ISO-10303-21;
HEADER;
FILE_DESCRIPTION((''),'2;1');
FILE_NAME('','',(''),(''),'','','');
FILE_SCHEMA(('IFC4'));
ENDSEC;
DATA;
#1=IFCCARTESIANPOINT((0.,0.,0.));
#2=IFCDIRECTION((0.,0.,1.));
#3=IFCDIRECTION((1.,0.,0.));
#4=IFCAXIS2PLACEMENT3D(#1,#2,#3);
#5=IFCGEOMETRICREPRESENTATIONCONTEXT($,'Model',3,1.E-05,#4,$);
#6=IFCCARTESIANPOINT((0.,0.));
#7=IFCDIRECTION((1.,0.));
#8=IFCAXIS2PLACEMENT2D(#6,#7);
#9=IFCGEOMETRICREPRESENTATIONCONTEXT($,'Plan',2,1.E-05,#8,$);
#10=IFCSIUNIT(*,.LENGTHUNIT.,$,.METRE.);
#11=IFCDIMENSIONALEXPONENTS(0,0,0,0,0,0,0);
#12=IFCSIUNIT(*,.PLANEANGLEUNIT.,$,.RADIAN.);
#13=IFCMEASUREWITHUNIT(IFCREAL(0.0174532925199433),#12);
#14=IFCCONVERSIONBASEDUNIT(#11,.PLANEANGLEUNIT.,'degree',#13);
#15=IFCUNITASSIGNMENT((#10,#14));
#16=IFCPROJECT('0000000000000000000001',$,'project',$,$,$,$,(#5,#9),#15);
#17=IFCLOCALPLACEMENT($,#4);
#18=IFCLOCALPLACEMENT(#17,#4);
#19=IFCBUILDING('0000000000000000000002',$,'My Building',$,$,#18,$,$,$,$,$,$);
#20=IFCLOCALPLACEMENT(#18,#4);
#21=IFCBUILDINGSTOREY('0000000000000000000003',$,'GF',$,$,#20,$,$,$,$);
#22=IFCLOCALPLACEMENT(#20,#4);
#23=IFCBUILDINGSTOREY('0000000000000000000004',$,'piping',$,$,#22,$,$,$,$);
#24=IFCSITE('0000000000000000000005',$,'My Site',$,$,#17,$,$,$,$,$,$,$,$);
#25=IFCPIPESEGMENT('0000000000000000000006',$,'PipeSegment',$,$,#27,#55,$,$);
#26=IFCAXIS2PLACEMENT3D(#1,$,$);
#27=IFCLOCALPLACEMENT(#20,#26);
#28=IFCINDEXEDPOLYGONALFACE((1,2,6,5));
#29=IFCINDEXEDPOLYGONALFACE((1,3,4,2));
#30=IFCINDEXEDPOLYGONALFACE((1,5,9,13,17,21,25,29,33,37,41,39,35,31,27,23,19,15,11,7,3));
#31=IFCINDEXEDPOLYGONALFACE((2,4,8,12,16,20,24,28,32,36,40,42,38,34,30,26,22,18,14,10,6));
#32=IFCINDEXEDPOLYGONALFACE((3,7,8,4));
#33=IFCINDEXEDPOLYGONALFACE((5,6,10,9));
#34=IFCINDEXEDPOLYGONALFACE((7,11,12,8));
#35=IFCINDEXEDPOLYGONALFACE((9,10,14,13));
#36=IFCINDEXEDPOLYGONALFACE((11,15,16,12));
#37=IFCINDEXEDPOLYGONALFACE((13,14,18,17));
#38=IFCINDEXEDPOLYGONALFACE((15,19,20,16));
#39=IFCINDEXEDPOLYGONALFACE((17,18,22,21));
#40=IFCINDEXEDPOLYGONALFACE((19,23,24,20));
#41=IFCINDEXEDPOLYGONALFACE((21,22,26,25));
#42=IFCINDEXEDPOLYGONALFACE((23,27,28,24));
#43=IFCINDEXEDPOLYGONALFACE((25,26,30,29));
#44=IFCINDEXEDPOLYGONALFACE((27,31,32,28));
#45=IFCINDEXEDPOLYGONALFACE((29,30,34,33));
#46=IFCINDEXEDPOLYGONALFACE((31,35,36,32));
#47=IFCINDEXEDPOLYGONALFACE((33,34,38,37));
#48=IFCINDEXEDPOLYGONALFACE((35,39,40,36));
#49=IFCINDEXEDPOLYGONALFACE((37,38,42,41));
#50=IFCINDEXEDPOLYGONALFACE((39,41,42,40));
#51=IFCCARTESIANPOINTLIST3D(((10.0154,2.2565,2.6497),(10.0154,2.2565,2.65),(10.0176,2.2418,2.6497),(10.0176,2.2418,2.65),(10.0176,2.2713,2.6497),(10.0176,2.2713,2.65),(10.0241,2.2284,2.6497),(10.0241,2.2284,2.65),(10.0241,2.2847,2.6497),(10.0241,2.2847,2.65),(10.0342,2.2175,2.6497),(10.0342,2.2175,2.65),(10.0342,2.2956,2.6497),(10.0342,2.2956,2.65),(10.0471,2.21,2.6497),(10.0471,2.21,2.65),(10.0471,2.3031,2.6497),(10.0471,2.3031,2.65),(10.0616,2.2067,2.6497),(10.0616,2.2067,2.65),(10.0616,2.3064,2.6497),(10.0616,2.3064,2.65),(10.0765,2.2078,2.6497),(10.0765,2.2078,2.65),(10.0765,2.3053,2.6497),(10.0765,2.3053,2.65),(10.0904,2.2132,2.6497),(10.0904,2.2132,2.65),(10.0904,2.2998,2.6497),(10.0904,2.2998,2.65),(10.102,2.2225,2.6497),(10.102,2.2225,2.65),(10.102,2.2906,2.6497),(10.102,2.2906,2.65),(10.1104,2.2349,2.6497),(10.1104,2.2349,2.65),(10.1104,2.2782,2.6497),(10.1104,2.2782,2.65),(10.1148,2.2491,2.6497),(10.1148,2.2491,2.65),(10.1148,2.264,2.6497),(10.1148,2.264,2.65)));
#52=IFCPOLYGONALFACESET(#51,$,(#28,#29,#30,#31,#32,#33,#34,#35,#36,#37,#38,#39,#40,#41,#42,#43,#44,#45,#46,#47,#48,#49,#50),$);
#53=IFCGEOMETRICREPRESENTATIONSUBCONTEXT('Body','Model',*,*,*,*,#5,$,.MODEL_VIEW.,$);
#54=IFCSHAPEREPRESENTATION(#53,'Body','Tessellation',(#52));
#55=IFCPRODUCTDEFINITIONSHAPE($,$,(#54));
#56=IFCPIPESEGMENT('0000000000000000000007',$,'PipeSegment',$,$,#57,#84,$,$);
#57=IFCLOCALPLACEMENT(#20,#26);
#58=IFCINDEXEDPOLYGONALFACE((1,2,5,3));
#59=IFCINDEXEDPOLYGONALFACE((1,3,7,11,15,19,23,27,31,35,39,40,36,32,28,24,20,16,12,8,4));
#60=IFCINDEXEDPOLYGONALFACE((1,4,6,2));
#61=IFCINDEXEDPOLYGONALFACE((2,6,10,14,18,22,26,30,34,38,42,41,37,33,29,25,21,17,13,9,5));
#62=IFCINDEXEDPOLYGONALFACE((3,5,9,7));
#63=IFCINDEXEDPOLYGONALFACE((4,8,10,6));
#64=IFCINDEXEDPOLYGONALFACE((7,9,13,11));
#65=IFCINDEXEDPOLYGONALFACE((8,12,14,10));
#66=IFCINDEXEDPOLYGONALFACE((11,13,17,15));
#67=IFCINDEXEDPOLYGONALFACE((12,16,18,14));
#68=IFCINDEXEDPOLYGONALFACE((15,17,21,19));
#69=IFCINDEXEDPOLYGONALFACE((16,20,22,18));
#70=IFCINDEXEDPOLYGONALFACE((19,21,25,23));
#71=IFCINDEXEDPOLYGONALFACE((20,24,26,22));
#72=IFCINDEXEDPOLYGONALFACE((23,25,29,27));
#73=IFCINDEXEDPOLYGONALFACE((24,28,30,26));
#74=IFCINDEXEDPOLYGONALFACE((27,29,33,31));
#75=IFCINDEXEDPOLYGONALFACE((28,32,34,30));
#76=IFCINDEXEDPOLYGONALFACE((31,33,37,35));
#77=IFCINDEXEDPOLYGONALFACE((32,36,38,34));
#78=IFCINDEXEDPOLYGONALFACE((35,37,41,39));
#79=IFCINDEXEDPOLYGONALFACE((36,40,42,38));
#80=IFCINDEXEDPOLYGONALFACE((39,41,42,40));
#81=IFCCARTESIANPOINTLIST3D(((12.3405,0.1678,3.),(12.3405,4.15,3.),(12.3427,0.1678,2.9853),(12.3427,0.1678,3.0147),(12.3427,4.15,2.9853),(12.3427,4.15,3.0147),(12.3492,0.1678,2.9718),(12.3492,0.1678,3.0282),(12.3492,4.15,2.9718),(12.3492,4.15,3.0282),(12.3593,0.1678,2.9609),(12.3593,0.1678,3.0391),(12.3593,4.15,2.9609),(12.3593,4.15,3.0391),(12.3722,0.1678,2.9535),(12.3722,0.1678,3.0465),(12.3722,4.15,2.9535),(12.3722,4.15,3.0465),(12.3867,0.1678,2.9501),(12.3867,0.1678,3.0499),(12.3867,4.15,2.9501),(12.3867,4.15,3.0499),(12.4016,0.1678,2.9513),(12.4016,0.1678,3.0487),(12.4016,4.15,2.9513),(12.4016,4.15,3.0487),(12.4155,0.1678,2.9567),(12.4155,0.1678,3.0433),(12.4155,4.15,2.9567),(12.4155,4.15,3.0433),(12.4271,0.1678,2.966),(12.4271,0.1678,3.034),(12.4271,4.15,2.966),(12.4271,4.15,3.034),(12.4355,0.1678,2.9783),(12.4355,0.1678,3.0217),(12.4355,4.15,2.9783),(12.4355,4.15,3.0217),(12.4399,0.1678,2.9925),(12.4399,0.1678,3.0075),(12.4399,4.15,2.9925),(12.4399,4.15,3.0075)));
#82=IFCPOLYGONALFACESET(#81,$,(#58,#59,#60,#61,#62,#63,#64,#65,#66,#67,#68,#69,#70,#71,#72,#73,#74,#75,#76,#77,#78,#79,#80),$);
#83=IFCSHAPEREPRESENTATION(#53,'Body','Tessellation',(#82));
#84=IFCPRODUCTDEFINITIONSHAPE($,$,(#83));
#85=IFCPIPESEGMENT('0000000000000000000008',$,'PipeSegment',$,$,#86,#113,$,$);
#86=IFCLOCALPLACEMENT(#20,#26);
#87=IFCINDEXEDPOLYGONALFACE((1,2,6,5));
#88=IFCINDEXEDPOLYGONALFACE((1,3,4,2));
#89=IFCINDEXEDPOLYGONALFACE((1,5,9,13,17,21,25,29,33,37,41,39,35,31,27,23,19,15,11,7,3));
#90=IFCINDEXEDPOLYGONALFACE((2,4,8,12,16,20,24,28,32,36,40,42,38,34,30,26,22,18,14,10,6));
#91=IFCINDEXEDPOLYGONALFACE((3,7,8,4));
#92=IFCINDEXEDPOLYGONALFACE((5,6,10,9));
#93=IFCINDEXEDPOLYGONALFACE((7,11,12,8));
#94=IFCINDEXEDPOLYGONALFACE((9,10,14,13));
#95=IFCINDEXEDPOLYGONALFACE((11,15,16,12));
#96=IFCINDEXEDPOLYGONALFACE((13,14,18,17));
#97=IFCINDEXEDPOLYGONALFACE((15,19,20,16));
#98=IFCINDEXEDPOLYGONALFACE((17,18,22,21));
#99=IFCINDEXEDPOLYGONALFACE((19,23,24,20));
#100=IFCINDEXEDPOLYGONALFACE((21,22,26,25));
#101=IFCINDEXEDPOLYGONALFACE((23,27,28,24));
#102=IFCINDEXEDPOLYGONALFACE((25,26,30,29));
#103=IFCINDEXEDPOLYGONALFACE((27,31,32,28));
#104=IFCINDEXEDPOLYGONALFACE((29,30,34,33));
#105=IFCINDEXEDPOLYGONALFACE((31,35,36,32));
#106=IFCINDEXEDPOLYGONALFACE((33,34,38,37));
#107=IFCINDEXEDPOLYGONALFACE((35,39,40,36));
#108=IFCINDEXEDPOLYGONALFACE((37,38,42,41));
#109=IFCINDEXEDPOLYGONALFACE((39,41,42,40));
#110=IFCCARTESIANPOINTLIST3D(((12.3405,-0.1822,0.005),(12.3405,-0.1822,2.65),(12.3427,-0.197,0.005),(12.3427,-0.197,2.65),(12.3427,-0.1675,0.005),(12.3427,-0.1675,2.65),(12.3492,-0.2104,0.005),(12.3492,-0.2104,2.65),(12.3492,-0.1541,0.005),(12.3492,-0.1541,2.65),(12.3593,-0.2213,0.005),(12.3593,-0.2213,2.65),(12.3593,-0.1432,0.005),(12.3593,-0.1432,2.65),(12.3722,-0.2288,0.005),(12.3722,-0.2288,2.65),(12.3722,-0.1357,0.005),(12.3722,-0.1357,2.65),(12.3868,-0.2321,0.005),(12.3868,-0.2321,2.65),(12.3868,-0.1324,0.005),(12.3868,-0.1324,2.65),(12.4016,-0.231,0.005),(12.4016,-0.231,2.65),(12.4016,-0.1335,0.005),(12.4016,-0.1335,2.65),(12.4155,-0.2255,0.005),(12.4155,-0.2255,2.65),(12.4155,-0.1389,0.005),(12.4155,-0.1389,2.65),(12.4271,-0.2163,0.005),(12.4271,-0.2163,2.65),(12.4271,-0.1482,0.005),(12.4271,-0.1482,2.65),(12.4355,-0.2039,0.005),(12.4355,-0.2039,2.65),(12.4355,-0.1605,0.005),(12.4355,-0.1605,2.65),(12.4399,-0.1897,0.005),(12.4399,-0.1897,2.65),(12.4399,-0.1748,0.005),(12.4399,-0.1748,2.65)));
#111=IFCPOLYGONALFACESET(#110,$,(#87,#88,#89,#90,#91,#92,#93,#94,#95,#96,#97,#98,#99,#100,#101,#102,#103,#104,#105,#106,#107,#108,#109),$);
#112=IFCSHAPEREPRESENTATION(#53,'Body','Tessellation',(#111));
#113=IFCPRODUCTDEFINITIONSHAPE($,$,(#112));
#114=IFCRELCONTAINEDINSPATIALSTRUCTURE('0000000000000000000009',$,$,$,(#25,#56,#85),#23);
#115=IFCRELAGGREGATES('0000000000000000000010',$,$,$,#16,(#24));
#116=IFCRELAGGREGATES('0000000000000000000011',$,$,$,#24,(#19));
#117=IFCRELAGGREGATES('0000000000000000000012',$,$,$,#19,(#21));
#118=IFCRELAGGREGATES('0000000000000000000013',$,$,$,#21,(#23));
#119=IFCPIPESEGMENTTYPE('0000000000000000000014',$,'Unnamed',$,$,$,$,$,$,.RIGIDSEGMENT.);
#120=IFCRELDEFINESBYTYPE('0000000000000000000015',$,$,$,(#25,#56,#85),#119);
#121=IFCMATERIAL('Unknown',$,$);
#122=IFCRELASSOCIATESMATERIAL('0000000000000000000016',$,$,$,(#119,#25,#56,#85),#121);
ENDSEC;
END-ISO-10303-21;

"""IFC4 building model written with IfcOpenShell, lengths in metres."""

from ifc_helpers import new_model, entity, si_unit, converted_unit, frame, origin_with_axes, origin_2d_with_axis, place, context, subcontext, project, spatial, circle, extrude, material, material_profile, profile_set, profile_usage, type_object, element, save


model = new_model("IFC4")

# Units and contexts
model_context = context("Model", 3, precision=1e-05, world=origin_with_axes())
plan_context = context("Plan", 2, precision=1e-05, world=origin_2d_with_axis())
body_context = subcontext(model_context, "Body", "Model", "MODEL_VIEW")
ifc_project = project(units=[si_unit("LENGTHUNIT", "METRE"), converted_unit("PLANEANGLEUNIT", "degree", entity("IfcReal", 0.0174532925199433), si_unit("PLANEANGLEUNIT", "RADIAN"), dimensions=[0, 0, 0, 0, 0, 0, 0])], contexts=[model_context, plan_context])

# Site, building, storeys
site_placement = place(None, origin_with_axes())
site = spatial("IfcSite", under=ifc_project, at=site_placement, Name="My Site")
building_placement = place(site_placement, origin_with_axes())
building = spatial("IfcBuilding", under=site, at=building_placement, Name="My Building")
storey_1_placement = place(building_placement, origin_with_axes())
storey_1 = spatial("IfcBuildingStorey", under=building, at=storey_1_placement, Name="GF")
storey_2_placement = place(storey_1_placement, origin_with_axes())
storey_2 = spatial("IfcBuildingStorey", under=storey_1, at=storey_2_placement, Name="piping")

# Pipe segments
ifc_material = material(Name="Unknown")
ifc_material_profile = material_profile(ifc_material, circle(Radius=0.05))
ifc_profile_set = profile_set([ifc_material_profile])
pipe_segment_type = type_object("IfcPipeSegmentType", Name="Unnamed", PredefinedType="RIGIDSEGMENT", material=ifc_profile_set)
ifc_profile_usage_1 = profile_usage(ifc_profile_set, cardinal=5)
pipe_segment_1_placement = place(storey_2_placement, frame((10.0654, 2.2565, 2.65), z_axis=(0.0, 0.0, -1.0), x_axis=(-1.0, 0.0, 0.0)))
element("IfcPipeSegment", 1, at=pipe_segment_1_placement, inside=storey_2, type_object=pipe_segment_type, material=ifc_profile_usage_1, Name="PipeSegment", context=body_context, shape_type="SweptSolid", body=[
    extrude(circle(Radius=0.05), origin_with_axes(), (0.0, 0.0, 1.0), 0.0003),
])
ifc_profile_usage_2 = profile_usage(ifc_profile_set, cardinal=5)
pipe_segment_2_placement = place(storey_2_placement, frame((12.3905, 0.1678, 3.0), z_axis=(0.0, 1.0, 0.0), x_axis=(-1.0, 0.0, 0.0)))
element("IfcPipeSegment", 2, at=pipe_segment_2_placement, inside=storey_2, type_object=pipe_segment_type, material=ifc_profile_usage_2, Name="PipeSegment", context=body_context, shape_type="SweptSolid", body=[
    extrude(circle(Radius=0.05), origin_with_axes(), (0.0, 0.0, 1.0), 3.9822),
])
ifc_profile_usage_3 = profile_usage(ifc_profile_set, cardinal=5)
pipe_segment_3_placement = place(storey_2_placement, frame((12.3905, -0.1822, 2.65), z_axis=(0.0, 0.0, -1.0), x_axis=(-1.0, 0.0, 0.0)))
element("IfcPipeSegment", 3, at=pipe_segment_3_placement, inside=storey_2, type_object=pipe_segment_type, material=ifc_profile_usage_3, Name="PipeSegment", context=body_context, shape_type="SweptSolid", body=[
    extrude(circle(Radius=0.05), origin_with_axes(), (0.0, 0.0, 1.0), 2.645),
])

save(model, "model.ifc")
